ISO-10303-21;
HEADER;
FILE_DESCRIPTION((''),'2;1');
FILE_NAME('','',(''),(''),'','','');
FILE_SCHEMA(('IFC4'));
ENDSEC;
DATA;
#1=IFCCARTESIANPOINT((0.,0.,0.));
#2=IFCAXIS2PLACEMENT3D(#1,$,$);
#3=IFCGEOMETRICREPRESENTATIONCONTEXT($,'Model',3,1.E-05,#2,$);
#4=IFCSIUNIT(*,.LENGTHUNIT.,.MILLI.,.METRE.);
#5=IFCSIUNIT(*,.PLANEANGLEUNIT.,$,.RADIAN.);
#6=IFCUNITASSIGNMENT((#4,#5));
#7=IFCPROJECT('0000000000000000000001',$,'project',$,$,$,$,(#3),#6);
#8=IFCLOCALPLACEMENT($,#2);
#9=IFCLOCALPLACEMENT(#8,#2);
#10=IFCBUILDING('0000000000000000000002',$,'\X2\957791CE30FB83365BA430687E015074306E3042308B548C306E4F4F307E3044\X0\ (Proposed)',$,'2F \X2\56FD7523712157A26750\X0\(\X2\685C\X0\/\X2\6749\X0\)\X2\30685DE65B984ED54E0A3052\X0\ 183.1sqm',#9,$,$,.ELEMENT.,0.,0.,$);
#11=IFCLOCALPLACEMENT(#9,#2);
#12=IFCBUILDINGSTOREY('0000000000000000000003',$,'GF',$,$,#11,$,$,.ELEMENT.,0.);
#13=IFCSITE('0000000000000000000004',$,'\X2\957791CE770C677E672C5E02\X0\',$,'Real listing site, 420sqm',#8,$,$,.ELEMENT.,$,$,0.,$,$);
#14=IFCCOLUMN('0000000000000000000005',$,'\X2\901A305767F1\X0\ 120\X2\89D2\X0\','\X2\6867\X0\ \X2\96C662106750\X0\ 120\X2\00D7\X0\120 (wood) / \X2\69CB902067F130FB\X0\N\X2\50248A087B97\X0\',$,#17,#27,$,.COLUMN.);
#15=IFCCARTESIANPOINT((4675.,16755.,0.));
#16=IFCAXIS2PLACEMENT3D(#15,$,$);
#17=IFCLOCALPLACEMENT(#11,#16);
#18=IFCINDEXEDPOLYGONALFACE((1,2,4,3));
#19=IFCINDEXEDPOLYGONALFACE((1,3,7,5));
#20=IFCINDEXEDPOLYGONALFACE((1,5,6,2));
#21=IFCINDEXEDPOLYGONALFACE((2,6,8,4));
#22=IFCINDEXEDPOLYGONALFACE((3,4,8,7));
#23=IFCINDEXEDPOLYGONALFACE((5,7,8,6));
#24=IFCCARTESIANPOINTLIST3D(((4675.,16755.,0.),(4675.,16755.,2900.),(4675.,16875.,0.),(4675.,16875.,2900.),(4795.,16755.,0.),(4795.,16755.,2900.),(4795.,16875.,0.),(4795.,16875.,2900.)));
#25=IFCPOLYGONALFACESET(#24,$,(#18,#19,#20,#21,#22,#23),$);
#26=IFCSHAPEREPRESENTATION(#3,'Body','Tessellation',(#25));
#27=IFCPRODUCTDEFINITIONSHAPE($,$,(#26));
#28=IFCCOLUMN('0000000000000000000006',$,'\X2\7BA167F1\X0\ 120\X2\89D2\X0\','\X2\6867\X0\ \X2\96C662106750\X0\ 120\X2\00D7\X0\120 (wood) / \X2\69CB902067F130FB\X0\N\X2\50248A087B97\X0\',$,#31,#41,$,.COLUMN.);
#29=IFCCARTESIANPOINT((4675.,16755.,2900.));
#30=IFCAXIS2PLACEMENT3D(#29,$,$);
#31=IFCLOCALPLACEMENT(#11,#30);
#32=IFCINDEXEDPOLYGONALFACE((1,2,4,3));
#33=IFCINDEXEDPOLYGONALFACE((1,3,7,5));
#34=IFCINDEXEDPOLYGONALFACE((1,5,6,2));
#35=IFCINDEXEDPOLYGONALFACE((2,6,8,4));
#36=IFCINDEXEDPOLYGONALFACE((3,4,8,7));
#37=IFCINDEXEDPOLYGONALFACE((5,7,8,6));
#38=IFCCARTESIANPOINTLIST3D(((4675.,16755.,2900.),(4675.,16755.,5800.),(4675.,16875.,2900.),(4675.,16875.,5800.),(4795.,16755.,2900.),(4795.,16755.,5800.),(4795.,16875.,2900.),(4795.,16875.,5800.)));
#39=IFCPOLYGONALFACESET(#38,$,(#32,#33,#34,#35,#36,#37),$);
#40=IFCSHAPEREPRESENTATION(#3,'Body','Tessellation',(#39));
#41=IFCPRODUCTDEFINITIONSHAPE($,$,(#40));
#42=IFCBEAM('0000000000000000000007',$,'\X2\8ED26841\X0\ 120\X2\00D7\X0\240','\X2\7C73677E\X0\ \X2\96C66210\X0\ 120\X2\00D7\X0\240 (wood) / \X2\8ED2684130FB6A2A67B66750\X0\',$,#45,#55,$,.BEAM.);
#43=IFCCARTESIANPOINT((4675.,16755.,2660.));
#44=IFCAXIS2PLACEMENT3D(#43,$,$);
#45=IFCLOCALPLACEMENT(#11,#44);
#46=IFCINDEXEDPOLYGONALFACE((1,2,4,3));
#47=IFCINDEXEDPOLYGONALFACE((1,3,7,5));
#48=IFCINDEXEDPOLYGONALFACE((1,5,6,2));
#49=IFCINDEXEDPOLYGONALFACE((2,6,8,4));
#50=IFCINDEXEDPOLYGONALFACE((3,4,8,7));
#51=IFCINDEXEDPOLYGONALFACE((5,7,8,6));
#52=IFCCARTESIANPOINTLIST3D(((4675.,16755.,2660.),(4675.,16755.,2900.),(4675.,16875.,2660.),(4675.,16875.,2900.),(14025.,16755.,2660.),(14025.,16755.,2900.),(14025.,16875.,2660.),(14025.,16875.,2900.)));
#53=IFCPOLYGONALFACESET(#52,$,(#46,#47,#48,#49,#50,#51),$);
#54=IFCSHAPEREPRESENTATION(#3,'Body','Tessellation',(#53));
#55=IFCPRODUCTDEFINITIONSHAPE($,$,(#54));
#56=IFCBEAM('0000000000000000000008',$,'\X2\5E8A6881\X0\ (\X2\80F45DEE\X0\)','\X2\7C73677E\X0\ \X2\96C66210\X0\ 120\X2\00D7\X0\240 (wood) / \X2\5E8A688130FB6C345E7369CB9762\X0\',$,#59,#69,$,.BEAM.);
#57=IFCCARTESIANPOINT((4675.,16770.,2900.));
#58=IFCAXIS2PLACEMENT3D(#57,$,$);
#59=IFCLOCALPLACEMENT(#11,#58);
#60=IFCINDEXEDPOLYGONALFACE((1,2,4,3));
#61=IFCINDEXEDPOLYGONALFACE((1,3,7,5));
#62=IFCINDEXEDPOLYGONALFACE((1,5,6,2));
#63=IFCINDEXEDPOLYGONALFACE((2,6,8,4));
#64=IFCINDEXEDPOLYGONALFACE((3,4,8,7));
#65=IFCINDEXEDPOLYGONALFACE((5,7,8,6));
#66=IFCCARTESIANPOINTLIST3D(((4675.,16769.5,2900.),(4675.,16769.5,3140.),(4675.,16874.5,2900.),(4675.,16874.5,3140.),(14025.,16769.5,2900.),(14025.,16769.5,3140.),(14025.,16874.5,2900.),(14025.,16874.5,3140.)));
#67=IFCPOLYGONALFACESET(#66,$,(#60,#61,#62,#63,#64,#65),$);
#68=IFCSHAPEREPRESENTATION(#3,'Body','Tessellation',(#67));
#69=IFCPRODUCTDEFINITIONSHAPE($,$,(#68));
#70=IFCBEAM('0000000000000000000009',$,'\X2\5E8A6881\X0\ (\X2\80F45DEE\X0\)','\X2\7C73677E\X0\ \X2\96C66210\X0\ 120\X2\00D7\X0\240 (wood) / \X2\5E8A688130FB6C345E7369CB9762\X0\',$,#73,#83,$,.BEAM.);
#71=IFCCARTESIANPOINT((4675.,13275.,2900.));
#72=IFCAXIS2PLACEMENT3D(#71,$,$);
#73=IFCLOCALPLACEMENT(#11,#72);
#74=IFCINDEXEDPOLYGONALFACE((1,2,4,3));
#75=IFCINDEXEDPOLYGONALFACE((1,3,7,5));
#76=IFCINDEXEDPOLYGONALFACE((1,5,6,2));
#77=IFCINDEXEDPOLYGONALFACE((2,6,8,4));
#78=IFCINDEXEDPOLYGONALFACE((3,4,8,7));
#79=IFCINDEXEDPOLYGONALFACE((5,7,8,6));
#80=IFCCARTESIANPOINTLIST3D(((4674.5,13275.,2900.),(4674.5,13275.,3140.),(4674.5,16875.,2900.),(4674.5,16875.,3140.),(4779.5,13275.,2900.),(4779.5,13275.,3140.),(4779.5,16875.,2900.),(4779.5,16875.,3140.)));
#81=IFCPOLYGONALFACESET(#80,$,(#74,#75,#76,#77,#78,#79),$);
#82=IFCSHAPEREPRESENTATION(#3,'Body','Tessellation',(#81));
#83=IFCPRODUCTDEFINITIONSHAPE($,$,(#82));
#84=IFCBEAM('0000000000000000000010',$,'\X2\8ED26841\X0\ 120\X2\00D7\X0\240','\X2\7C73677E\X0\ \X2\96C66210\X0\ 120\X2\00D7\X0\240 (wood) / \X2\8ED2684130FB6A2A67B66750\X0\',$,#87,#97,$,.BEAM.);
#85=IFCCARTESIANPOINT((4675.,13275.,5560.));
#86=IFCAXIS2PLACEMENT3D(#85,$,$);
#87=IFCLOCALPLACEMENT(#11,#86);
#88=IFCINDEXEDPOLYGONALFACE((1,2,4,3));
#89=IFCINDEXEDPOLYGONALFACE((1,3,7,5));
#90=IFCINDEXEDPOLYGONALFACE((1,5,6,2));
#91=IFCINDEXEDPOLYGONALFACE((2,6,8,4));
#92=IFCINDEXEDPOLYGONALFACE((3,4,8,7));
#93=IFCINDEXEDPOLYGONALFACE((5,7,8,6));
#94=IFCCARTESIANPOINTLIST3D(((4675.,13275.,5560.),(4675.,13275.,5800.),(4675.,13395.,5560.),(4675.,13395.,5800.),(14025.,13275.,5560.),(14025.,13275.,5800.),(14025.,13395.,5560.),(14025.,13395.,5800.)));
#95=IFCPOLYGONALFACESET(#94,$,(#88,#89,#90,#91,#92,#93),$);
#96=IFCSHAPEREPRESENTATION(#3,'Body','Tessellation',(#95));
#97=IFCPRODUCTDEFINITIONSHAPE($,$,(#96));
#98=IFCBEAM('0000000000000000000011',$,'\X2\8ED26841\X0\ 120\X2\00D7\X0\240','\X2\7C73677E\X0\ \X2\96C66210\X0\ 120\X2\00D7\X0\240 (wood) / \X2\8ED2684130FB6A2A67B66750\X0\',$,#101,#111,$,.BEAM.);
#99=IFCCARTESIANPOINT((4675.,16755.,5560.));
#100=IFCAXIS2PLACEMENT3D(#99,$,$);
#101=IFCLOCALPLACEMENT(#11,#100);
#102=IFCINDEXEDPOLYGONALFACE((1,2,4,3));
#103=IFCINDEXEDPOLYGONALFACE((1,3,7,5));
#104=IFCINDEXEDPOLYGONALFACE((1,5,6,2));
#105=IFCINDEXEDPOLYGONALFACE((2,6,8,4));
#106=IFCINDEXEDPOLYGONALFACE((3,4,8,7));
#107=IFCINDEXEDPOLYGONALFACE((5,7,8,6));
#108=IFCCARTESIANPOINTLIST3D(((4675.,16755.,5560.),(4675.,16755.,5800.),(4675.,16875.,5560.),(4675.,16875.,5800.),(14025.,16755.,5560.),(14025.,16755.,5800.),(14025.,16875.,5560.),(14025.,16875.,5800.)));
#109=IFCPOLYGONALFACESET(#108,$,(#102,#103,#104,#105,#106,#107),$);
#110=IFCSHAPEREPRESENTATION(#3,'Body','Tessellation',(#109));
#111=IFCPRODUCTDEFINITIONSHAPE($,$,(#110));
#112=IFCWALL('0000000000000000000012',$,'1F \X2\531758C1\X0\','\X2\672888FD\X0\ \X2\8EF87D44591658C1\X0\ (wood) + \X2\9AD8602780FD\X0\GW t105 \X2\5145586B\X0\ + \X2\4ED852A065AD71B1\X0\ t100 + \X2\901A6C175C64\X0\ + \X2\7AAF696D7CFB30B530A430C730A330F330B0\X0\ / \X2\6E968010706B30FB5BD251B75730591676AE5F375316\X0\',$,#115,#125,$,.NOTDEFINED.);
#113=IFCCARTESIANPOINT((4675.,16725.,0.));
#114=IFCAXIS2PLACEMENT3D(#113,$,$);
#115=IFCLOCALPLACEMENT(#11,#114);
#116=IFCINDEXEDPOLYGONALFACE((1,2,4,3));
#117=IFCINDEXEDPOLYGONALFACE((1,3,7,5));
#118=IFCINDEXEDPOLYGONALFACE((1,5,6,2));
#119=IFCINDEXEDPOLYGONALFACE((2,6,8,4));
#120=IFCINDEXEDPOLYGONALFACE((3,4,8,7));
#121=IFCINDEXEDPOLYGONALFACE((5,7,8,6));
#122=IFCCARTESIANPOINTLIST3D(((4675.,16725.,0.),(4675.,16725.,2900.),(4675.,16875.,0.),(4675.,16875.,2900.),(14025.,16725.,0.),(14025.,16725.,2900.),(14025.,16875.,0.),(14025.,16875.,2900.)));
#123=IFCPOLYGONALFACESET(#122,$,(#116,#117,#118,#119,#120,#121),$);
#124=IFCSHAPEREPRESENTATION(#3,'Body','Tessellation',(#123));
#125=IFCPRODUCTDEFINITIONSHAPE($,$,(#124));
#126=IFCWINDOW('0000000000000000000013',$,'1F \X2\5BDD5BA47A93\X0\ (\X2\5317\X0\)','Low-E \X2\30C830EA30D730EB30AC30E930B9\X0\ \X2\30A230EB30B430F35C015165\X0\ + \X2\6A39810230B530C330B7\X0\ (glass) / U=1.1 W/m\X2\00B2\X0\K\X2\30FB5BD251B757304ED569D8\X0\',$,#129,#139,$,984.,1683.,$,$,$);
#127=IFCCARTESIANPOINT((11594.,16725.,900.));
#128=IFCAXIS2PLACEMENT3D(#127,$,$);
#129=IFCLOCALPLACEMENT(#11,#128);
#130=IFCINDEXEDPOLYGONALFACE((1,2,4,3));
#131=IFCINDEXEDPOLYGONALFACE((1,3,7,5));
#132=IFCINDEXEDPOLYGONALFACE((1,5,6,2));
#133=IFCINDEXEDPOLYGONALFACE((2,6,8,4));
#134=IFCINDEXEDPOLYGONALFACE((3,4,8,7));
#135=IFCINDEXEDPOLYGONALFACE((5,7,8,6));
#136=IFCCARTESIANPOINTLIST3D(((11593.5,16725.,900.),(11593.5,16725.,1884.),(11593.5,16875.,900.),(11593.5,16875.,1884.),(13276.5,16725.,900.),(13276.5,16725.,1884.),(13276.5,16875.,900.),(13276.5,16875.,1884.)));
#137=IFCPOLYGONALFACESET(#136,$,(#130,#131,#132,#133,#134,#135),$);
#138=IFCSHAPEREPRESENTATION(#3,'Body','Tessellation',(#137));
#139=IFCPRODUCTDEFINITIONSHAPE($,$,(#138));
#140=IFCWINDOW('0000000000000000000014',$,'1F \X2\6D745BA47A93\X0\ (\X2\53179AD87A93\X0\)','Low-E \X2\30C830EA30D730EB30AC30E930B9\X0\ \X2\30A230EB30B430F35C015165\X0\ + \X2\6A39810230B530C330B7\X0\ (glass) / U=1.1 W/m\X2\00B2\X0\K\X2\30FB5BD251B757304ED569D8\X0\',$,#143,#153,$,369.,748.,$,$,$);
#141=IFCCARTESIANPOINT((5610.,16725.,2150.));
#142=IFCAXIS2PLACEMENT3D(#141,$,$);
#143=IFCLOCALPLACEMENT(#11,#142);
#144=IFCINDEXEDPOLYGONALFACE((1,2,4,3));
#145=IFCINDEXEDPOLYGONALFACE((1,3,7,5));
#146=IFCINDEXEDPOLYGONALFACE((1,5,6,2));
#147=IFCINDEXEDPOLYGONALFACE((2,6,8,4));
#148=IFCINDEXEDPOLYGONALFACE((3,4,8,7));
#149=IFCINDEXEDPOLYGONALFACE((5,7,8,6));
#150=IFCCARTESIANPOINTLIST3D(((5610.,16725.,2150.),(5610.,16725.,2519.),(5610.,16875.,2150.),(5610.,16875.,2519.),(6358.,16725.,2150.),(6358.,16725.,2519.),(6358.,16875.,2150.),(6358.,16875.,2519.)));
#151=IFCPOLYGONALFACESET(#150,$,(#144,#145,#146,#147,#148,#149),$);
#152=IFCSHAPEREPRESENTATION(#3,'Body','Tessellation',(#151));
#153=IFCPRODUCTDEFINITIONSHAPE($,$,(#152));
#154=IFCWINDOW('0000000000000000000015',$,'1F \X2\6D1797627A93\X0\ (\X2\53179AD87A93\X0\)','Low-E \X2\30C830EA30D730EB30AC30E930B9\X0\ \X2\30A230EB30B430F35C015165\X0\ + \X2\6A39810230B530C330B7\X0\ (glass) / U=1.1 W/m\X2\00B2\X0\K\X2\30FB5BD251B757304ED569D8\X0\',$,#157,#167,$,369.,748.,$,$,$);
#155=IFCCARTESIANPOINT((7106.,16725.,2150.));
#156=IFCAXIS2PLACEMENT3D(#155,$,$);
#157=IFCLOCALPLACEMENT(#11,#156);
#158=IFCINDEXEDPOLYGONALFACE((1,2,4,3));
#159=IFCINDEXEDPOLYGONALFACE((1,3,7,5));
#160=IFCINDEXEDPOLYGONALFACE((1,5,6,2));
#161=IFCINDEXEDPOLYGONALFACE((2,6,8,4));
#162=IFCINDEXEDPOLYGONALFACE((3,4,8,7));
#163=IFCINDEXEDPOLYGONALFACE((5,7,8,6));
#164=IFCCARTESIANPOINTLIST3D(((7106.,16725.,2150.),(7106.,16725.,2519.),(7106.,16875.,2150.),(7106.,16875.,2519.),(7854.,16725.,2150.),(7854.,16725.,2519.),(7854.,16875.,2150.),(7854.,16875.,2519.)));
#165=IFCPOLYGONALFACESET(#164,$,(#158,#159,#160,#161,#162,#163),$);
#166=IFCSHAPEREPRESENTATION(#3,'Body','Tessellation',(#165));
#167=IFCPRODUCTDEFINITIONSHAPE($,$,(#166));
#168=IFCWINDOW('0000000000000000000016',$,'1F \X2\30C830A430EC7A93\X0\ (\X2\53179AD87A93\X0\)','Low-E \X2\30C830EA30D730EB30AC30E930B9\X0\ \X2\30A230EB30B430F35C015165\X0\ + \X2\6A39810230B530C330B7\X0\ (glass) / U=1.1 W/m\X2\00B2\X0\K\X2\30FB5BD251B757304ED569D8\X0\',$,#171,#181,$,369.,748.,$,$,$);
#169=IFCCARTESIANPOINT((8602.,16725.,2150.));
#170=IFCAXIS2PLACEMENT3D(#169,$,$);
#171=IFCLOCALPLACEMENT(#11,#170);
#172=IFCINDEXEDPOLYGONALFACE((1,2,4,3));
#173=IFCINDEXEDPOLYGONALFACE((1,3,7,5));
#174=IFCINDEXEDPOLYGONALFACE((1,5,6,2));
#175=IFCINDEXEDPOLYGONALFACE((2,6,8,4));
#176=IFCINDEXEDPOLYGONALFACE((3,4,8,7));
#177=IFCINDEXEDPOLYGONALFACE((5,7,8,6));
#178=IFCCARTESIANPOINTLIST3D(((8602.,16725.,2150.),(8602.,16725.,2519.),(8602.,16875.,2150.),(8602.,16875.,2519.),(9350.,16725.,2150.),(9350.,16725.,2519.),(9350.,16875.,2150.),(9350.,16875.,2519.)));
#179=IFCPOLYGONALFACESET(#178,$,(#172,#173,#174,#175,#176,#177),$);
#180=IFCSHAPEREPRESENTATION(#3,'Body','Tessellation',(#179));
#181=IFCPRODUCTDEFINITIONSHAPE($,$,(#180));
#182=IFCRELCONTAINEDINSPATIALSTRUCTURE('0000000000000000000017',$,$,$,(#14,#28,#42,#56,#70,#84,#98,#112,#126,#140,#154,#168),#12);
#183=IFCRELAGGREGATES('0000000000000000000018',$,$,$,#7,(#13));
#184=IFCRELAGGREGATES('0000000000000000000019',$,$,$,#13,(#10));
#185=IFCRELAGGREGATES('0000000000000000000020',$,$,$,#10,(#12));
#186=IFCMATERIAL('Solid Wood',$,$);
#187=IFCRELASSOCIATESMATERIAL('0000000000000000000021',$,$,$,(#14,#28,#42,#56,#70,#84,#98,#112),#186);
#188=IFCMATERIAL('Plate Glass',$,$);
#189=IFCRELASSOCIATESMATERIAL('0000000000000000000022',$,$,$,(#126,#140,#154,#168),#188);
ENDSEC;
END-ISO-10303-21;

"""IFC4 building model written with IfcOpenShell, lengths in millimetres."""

from ifc_helpers import new_model, si_unit, frame, frame_2d, origin, place, context, project, spatial, rectangle, extrude, material, element, fill, save


model = new_model("IFC4")

# Units and contexts
model_context = context("Model", 3, precision=1e-05, world=origin())
ifc_project = project(units=[si_unit("LENGTHUNIT", "METRE", prefix="MILLI"), si_unit("PLANEANGLEUNIT", "RADIAN")], contexts=[model_context])

# Site, building, storey
site_placement = place(None, origin())
site = spatial("IfcSite", under=ifc_project, at=site_placement, Name="長野県松本市", ObjectType="Real listing site, 420sqm", CompositionType="ELEMENT", RefElevation=0.0)
building_placement = place(site_placement, origin())
building = spatial("IfcBuilding", under=site, at=building_placement, Name="長野・茶室と縁側のある和の住まい (Proposed)", ObjectType="2F 国産無垢材(桜/杉)と左官仕上げ 183.1sqm", CompositionType="ELEMENT", ElevationOfRefHeight=0.0, ElevationOfTerrain=0.0)
storey_placement = place(building_placement, origin())
storey = spatial("IfcBuildingStorey", under=building, at=storey_placement, Name="GF", CompositionType="ELEMENT", Elevation=0.0)

# Columns
ifc_material_1 = material(Name="Solid Wood")
column_1_placement = place(storey_placement, frame((4675.0, 16755.0, 0.0)))
element("IfcColumn", 1, at=column_1_placement, inside=storey, material=ifc_material_1, Name="通し柱 120角", Description="桧 集成材 120×120 (wood) / 構造柱・N値計算", PredefinedType="COLUMN", context=model_context, shape_type="SweptSolid", body=[
    extrude(rectangle(XDim=120.0, YDim=120.0, at=frame_2d((60.0, 60.0))), frame((4675.0, 16755.0, 0.0)), (0.0, 0.0, 1.0), 2900.0),
])
column_2_placement = place(storey_placement, frame((4675.0, 16755.0, 2900.0)))
element("IfcColumn", 2, at=column_2_placement, inside=storey, material=ifc_material_1, Name="管柱 120角", Description="桧 集成材 120×120 (wood) / 構造柱・N値計算", PredefinedType="COLUMN", context=model_context, shape_type="SweptSolid", body=[
    extrude(rectangle(XDim=120.0, YDim=120.0, at=frame_2d((60.0, 60.0))), frame((4675.0, 16755.0, 2900.0)), (0.0, 0.0, 1.0), 2900.0),
])

# Beams
beam_1_placement = place(storey_placement, frame((4675.0, 16755.0, 2660.0)))
element("IfcBeam", 3, at=beam_1_placement, inside=storey, material=ifc_material_1, Name="軒桁 120×240", Description="米松 集成 120×240 (wood) / 軒桁・横架材", PredefinedType="BEAM", context=model_context, shape_type="SweptSolid", body=[
    extrude(rectangle(XDim=9350.0, YDim=120.0, at=frame_2d((4675.0, 60.0))), frame((4675.0, 16755.0, 2660.0)), (0.0, 0.0, 1.0), 240.0),
])
beam_2_placement = place(storey_placement, frame((4675.0, 16770.0, 2900.0)))
element("IfcBeam", 4, at=beam_2_placement, inside=storey, material=ifc_material_1, Name="床梁 (胴差)", Description="米松 集成 120×240 (wood) / 床梁・水平構面", PredefinedType="BEAM", context=model_context, shape_type="SweptSolid", body=[
    extrude(rectangle(XDim=9350.0, YDim=105.0, at=frame_2d((4675.0, 52.0))), frame((4675.0, 16770.0, 2900.0)), (0.0, 0.0, 1.0), 240.0),
])
beam_3_placement = place(storey_placement, frame((4675.0, 13275.0, 2900.0)))
element("IfcBeam", 5, at=beam_3_placement, inside=storey, material=ifc_material_1, Name="床梁 (胴差)", Description="米松 集成 120×240 (wood) / 床梁・水平構面", PredefinedType="BEAM", context=model_context, shape_type="SweptSolid", body=[
    extrude(rectangle(XDim=105.0, YDim=3600.0, at=frame_2d((52.0, 1800.0))), frame((4675.0, 13275.0, 2900.0)), (0.0, 0.0, 1.0), 240.0),
])
beam_4_placement = place(storey_placement, frame((4675.0, 13275.0, 5560.0)))
element("IfcBeam", 6, at=beam_4_placement, inside=storey, material=ifc_material_1, Name="軒桁 120×240", Description="米松 集成 120×240 (wood) / 軒桁・横架材", PredefinedType="BEAM", context=model_context, shape_type="SweptSolid", body=[
    extrude(rectangle(XDim=9350.0, YDim=120.0, at=frame_2d((4675.0, 60.0))), frame((4675.0, 13275.0, 5560.0)), (0.0, 0.0, 1.0), 240.0),
])
beam_5_placement = place(storey_placement, frame((4675.0, 16755.0, 5560.0)))
element("IfcBeam", 7, at=beam_5_placement, inside=storey, material=ifc_material_1, Name="軒桁 120×240", Description="米松 集成 120×240 (wood) / 軒桁・横架材", PredefinedType="BEAM", context=model_context, shape_type="SweptSolid", body=[
    extrude(rectangle(XDim=9350.0, YDim=120.0, at=frame_2d((4675.0, 60.0))), frame((4675.0, 16755.0, 5560.0)), (0.0, 0.0, 1.0), 240.0),
])

# Wall, openings, windows
wall_1_placement = place(storey_placement, frame((4675.0, 16725.0, 0.0)))
wall_1 = element("IfcWall", 8, at=wall_1_placement, inside=storey, material=ifc_material_1, Name="1F 北壁", Description="木製 軸組外壁 (wood) + 高性能GW t105 充填 + 付加断熱 t100 + 通気層 + 窯業系サイディング / 準耐火・寒冷地外皮強化", PredefinedType="NOTDEFINED", context=model_context, shape_type="SweptSolid", body=[
    extrude(rectangle(XDim=9350.0, YDim=150.0, at=frame_2d((4675.0, 75.0))), frame((4675.0, 16725.0, 0.0)), (0.0, 0.0, 1.0), 2900.0),
])
opening_1_placement = place(storey_placement, frame((11594.0, 16725.0, 900.0)))
opening_1 = element("IfcOpeningElement", 9, at=opening_1_placement, cuts=wall_1, PredefinedType="NOTDEFINED", context=model_context, shape_type="SweptSolid", body=[
    extrude(rectangle(XDim=1683.0, YDim=150.0, at=frame_2d((841.0, 75.0))), frame((11594.0, 16725.0, 900.0)), (0.0, 0.0, 1.0), 984.0),
])
opening_2_placement = place(storey_placement, frame((5610.0, 16725.0, 2150.0)))
opening_2 = element("IfcOpeningElement", 10, at=opening_2_placement, cuts=wall_1, PredefinedType="NOTDEFINED", context=model_context, shape_type="SweptSolid", body=[
    extrude(rectangle(XDim=748.0, YDim=150.0, at=frame_2d((374.0, 75.0))), frame((5610.0, 16725.0, 2150.0)), (0.0, 0.0, 1.0), 369.0),
])
opening_3_placement = place(storey_placement, frame((7106.0, 16725.0, 2150.0)))
opening_3 = element("IfcOpeningElement", 11, at=opening_3_placement, cuts=wall_1, PredefinedType="NOTDEFINED", context=model_context, shape_type="SweptSolid", body=[
    extrude(rectangle(XDim=748.0, YDim=150.0, at=frame_2d((374.0, 75.0))), frame((7106.0, 16725.0, 2150.0)), (0.0, 0.0, 1.0), 369.0),
])
opening_4_placement = place(storey_placement, frame((8602.0, 16725.0, 2150.0)))
opening_4 = element("IfcOpeningElement", 12, at=opening_4_placement, cuts=wall_1, PredefinedType="NOTDEFINED", context=model_context, shape_type="SweptSolid", body=[
    extrude(rectangle(XDim=748.0, YDim=150.0, at=frame_2d((374.0, 75.0))), frame((8602.0, 16725.0, 2150.0)), (0.0, 0.0, 1.0), 369.0),
])
ifc_material_2 = material(Name="Plate Glass")
window_1_placement = place(storey_placement, frame((11594.0, 16725.0, 900.0)))
window_1 = element("IfcWindow", 13, at=window_1_placement, inside=storey, material=ifc_material_2, Name="1F 寝室窓 (北)", Description="Low-E トリプルガラス アルゴン封入 + 樹脂サッシ (glass) / U=1.1 W/m²K・寒冷地仕様", OverallHeight=984.0, OverallWidth=1683.0, context=model_context, shape_type="SweptSolid", body=[
    extrude(rectangle(XDim=1683.0, YDim=150.0, at=frame_2d((841.0, 75.0))), frame((11594.0, 16725.0, 900.0)), (0.0, 0.0, 1.0), 984.0),
])
fill(opening_1, window_1)
window_2_placement = place(storey_placement, frame((5610.0, 16725.0, 2150.0)))
window_2 = element("IfcWindow", 14, at=window_2_placement, inside=storey, material=ifc_material_2, Name="1F 浴室窓 (北高窓)", Description="Low-E トリプルガラス アルゴン封入 + 樹脂サッシ (glass) / U=1.1 W/m²K・寒冷地仕様", OverallHeight=369.0, OverallWidth=748.0, context=model_context, shape_type="SweptSolid", body=[
    extrude(rectangle(XDim=748.0, YDim=150.0, at=frame_2d((374.0, 75.0))), frame((5610.0, 16725.0, 2150.0)), (0.0, 0.0, 1.0), 369.0),
])
fill(opening_2, window_2)
window_3_placement = place(storey_placement, frame((7106.0, 16725.0, 2150.0)))
window_3 = element("IfcWindow", 15, at=window_3_placement, inside=storey, material=ifc_material_2, Name="1F 洗面窓 (北高窓)", Description="Low-E トリプルガラス アルゴン封入 + 樹脂サッシ (glass) / U=1.1 W/m²K・寒冷地仕様", OverallHeight=369.0, OverallWidth=748.0, context=model_context, shape_type="SweptSolid", body=[
    extrude(rectangle(XDim=748.0, YDim=150.0, at=frame_2d((374.0, 75.0))), frame((7106.0, 16725.0, 2150.0)), (0.0, 0.0, 1.0), 369.0),
])
fill(opening_3, window_3)
window_4_placement = place(storey_placement, frame((8602.0, 16725.0, 2150.0)))
window_4 = element("IfcWindow", 16, at=window_4_placement, inside=storey, material=ifc_material_2, Name="1F トイレ窓 (北高窓)", Description="Low-E トリプルガラス アルゴン封入 + 樹脂サッシ (glass) / U=1.1 W/m²K・寒冷地仕様", OverallHeight=369.0, OverallWidth=748.0, context=model_context, shape_type="SweptSolid", body=[
    extrude(rectangle(XDim=748.0, YDim=150.0, at=frame_2d((374.0, 75.0))), frame((8602.0, 16725.0, 2150.0)), (0.0, 0.0, 1.0), 369.0),
])
fill(opening_4, window_4)

save(model, "model.ifc")
